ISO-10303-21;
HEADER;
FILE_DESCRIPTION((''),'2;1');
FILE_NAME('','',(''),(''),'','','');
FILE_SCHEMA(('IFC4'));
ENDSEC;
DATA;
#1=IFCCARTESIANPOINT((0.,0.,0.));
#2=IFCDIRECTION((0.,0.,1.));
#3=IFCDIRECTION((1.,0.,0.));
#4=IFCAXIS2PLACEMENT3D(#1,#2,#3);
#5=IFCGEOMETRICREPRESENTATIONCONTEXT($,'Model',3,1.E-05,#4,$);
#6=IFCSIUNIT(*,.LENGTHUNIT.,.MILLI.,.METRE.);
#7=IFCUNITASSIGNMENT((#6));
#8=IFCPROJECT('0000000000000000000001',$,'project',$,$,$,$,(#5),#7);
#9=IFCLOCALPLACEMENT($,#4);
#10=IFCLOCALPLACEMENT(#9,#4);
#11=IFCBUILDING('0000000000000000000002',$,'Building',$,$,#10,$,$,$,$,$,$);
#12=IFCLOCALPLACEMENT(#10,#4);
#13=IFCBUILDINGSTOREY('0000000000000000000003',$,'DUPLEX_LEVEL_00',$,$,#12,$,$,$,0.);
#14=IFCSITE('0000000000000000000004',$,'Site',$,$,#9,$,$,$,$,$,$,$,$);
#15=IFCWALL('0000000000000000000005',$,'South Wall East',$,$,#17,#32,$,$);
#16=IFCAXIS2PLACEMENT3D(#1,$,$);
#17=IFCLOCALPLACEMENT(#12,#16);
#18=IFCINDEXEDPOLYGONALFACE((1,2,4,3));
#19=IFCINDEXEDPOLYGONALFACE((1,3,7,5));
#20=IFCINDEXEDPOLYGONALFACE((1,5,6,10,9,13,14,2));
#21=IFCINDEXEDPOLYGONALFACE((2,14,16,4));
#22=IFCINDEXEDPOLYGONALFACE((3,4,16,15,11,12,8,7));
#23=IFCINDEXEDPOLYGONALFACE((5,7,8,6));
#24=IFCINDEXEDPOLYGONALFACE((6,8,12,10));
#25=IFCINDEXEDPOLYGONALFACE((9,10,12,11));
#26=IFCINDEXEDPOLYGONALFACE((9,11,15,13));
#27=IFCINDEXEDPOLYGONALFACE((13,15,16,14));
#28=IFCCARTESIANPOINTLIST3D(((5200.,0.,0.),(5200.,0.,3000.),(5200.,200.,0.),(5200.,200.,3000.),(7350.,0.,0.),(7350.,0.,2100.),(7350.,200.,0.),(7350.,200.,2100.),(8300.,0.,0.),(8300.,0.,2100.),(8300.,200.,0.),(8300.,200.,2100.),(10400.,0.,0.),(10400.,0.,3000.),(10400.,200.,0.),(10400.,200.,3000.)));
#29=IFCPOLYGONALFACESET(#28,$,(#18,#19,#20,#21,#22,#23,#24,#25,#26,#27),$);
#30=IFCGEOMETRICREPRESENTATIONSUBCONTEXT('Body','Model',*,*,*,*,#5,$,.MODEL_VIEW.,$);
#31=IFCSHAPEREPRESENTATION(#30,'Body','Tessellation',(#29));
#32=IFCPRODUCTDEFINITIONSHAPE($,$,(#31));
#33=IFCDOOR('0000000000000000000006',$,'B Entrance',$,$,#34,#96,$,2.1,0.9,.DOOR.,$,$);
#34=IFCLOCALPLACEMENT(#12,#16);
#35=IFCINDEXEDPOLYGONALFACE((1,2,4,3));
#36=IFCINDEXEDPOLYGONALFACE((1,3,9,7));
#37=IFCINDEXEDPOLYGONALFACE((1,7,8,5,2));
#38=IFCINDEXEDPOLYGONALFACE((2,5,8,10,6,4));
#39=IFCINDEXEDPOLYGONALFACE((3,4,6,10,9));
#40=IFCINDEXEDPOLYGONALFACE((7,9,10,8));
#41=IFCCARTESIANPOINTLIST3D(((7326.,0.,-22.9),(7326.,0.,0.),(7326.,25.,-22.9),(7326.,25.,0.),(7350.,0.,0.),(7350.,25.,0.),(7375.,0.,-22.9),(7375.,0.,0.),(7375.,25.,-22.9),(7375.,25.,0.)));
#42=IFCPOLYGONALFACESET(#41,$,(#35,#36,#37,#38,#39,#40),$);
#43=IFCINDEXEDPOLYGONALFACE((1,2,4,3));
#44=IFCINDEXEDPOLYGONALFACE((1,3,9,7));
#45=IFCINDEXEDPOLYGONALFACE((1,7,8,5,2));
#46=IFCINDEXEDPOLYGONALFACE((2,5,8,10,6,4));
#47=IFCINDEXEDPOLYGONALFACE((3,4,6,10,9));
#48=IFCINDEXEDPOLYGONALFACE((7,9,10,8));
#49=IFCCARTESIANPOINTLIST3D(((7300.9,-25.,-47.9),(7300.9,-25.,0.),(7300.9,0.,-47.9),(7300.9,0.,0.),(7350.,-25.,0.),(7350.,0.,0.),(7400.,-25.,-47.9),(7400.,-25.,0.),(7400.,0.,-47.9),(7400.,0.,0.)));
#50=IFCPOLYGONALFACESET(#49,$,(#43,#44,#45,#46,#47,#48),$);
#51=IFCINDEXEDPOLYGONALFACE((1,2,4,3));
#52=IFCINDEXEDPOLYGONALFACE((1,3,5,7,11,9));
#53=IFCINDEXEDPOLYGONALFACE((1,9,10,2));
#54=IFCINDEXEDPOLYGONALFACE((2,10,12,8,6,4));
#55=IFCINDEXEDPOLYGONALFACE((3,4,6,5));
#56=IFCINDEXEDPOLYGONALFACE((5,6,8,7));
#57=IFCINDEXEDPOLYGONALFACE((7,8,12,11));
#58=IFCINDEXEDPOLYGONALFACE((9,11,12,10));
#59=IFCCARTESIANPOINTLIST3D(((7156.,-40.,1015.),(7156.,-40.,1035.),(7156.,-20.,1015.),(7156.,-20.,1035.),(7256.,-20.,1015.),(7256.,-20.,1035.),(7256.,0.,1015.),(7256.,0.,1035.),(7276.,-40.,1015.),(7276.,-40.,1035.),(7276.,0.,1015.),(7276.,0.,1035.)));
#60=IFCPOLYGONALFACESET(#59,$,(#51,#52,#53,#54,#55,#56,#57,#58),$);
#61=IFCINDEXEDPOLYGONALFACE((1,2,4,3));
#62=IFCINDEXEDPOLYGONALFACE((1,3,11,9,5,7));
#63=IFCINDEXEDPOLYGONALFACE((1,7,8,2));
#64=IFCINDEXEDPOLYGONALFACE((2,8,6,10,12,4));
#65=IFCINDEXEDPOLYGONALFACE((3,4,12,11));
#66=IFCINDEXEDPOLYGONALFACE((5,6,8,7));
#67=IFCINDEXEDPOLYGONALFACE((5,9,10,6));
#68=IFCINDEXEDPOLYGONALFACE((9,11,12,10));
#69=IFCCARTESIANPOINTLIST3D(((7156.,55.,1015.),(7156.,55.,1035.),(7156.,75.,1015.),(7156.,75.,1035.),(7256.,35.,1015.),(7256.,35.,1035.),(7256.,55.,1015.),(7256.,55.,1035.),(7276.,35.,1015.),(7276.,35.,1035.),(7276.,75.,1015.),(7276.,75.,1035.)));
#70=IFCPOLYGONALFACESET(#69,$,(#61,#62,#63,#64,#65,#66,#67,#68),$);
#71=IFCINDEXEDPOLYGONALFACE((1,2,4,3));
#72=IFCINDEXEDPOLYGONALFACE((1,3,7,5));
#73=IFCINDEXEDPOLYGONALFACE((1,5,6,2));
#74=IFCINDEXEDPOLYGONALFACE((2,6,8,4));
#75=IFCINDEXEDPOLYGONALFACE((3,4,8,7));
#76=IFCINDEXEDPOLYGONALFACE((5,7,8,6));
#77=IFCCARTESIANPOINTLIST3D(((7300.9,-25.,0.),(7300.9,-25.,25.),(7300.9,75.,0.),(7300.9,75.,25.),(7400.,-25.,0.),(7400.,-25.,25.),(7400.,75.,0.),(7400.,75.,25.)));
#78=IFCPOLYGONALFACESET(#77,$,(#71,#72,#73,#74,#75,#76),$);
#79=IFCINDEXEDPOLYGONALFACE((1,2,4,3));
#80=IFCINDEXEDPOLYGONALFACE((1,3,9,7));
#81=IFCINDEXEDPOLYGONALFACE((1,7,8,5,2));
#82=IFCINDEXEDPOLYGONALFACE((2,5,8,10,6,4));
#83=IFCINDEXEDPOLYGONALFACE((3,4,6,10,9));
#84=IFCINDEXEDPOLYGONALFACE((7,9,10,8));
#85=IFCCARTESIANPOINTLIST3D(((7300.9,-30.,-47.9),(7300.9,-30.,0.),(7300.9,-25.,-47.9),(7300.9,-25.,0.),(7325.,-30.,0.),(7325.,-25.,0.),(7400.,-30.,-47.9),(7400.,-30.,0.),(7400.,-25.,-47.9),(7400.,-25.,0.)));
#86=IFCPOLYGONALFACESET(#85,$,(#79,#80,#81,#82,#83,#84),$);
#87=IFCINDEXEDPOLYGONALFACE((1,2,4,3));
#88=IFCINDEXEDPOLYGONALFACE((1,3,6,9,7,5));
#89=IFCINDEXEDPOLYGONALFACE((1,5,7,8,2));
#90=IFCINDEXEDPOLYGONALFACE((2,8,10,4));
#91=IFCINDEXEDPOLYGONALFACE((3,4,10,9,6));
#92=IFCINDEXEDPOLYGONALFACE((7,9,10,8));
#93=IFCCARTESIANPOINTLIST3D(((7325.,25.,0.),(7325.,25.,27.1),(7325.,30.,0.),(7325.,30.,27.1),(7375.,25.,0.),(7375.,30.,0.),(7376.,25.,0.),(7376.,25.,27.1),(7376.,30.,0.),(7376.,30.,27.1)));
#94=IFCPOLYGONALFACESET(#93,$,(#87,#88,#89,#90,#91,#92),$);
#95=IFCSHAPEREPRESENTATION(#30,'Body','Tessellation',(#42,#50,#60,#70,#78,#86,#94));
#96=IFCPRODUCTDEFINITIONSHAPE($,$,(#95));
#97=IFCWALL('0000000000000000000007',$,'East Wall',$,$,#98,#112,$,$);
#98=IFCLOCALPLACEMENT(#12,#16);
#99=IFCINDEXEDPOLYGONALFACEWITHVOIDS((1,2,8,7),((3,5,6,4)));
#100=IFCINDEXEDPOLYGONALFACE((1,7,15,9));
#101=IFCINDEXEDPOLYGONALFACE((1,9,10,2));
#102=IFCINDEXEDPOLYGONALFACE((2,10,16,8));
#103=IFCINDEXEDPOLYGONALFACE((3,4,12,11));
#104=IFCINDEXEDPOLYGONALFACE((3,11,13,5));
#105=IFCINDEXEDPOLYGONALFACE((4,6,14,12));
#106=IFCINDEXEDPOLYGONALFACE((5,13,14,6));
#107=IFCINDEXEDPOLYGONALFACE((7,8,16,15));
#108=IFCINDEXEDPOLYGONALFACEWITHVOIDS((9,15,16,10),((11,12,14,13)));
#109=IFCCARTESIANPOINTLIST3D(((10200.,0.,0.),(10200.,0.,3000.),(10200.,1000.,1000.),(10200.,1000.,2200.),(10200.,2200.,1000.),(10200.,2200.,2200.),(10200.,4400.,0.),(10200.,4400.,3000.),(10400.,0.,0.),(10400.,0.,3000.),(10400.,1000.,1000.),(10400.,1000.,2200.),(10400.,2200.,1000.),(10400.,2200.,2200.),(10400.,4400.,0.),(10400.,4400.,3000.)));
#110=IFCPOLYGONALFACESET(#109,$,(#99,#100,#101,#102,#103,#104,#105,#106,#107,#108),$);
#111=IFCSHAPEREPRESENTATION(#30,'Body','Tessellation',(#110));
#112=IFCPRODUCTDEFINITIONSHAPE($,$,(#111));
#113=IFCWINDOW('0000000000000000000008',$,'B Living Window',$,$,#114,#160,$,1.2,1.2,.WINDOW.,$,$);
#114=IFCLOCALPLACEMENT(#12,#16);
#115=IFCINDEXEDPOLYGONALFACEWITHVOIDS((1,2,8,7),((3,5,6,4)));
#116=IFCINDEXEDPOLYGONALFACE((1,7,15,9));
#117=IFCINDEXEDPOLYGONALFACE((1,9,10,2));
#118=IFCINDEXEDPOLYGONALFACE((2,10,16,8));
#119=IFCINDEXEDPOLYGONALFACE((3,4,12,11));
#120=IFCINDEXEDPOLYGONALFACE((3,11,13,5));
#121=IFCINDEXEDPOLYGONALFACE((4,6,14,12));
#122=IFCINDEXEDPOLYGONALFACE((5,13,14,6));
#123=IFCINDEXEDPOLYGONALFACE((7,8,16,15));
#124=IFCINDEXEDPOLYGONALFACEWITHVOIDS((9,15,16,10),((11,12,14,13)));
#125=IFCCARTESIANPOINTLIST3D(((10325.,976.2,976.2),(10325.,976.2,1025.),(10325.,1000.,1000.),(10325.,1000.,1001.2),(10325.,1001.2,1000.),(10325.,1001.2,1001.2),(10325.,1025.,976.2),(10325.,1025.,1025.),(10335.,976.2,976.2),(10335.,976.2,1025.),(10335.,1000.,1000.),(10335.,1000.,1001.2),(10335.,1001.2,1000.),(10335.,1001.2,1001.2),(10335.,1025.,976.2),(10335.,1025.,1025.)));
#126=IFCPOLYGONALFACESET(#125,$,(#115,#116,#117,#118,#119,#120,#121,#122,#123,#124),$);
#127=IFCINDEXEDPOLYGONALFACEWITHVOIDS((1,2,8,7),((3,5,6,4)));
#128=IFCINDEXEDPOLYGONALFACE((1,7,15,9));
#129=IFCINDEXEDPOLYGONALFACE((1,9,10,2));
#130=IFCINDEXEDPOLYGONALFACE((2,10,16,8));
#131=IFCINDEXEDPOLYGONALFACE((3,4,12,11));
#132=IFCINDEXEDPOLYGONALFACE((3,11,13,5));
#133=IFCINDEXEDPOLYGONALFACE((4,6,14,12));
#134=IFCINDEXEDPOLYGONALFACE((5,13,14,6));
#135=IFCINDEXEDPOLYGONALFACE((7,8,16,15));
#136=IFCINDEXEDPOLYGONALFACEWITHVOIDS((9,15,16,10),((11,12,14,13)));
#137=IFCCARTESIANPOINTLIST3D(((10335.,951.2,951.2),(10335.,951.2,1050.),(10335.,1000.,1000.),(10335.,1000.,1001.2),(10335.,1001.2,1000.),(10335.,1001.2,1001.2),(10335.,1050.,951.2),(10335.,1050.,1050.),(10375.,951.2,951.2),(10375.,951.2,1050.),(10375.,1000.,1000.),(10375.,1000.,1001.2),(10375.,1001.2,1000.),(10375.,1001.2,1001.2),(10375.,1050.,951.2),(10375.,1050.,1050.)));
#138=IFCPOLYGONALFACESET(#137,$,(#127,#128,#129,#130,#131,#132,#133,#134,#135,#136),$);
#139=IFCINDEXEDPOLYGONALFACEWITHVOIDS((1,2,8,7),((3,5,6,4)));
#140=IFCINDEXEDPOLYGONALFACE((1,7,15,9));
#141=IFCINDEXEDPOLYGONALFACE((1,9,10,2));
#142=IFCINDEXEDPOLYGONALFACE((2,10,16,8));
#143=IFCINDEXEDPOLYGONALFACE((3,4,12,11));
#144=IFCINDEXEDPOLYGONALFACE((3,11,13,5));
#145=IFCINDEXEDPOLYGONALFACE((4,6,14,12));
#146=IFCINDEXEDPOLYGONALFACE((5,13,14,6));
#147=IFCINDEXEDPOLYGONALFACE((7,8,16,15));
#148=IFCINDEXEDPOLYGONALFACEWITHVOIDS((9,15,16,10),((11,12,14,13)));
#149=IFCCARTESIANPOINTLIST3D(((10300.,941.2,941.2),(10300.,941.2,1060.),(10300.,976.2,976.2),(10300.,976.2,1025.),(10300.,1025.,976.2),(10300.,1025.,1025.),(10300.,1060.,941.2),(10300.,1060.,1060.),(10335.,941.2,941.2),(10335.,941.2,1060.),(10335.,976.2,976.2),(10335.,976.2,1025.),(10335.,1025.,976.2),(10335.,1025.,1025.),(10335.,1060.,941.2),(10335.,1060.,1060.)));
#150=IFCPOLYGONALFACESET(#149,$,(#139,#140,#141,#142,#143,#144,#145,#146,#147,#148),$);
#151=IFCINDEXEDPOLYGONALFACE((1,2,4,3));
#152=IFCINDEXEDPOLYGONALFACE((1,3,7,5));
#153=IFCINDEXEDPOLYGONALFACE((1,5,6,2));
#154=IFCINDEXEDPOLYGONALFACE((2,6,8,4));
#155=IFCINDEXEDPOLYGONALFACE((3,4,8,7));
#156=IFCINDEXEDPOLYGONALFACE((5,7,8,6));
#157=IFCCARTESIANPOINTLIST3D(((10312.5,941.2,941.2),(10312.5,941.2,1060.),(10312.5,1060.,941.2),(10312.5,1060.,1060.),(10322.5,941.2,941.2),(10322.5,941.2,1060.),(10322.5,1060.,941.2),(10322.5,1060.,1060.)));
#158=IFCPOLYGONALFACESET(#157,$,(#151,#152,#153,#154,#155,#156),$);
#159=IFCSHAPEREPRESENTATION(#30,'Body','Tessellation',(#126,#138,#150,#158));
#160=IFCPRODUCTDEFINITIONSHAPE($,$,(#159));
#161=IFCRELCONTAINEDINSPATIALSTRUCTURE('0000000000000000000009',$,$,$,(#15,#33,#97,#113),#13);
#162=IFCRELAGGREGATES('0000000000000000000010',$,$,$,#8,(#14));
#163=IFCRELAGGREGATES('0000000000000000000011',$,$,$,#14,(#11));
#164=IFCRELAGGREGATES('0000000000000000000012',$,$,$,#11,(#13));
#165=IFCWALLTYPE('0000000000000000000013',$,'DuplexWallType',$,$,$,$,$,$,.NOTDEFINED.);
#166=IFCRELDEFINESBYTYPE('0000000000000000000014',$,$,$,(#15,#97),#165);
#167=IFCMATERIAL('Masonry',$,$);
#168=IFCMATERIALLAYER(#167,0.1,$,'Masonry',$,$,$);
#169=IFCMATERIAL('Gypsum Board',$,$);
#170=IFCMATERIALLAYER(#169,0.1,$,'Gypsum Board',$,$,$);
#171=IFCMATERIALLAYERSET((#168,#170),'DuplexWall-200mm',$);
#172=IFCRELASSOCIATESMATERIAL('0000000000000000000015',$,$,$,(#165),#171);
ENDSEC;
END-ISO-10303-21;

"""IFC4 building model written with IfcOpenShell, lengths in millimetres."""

from ifc_helpers import new_model, si_unit, frame, origin_with_axes, place, context, subcontext, project, spatial, line, indexed_curve, outline, extrude, material, layer, layer_set, type_object, element, fill, save


model = new_model("IFC4")

# Units and contexts
model_context = context("Model", 3, precision=1e-05, world=origin_with_axes())
body_context = subcontext(model_context, "Body", "Model", "MODEL_VIEW")
ifc_project = project(units=[si_unit("LENGTHUNIT", "METRE", prefix="MILLI")], contexts=[model_context])

# Site, building, storey
site_placement = place(None, origin_with_axes())
site = spatial("IfcSite", under=ifc_project, at=site_placement, Name="Site")
building_placement = place(site_placement, origin_with_axes())
building = spatial("IfcBuilding", under=site, at=building_placement, Name="Building")
storey_placement = place(building_placement, origin_with_axes())
storey = spatial("IfcBuildingStorey", under=building, at=storey_placement, Name="DUPLEX_LEVEL_00", Elevation=0.0)

# Wall, opening, door
ifc_material_1 = material(Name="Masonry")
ifc_layer_1 = layer(ifc_material_1, 0.1, Name="Masonry")
ifc_material_2 = material(Name="Gypsum Board")
ifc_layer_2 = layer(ifc_material_2, 0.1, Name="Gypsum Board")
ifc_layer_set = layer_set([ifc_layer_1, ifc_layer_2], Name="DuplexWall-200mm")
wall_type = type_object("IfcWallType", Name="DuplexWallType", PredefinedType="NOTDEFINED", material=ifc_layer_set)
wall_1_placement = place(storey_placement, frame((5200.0, 0.0, 0.0), z_axis=(0.0, 0.0, 1.0), x_axis=(1.0, 0.0, 0.0)))
wall_1 = element("IfcWall", 1, at=wall_1_placement, inside=storey, type_object=wall_type, Name="South Wall East", context=body_context, shape_type="SweptSolid", body=[
    extrude(outline(indexed_curve([(0.0, 0.0), (0.0, 200.0), (5200.0, 200.0), (5200.0, 0.0), (0.0, 0.0)], self_intersect=False)), origin_with_axes(), (0.0, 0.0, 1.0), 3000.0),
])
opening_1_placement = place(wall_1_placement, frame((2150.0, -25.0, 0.0), z_axis=(0.0, 0.0, 1.0), x_axis=(1.0, 0.0, 0.0)))
opening_1 = element("IfcOpeningElement", 2, at=opening_1_placement, cuts=wall_1, context=body_context, shape_type="SweptSolid", body=[
    extrude(outline(indexed_curve([(0.0, 0.0), (0.0, 250.0), (950.0, 250.0), (950.0, 0.0), (0.0, 0.0)], self_intersect=False)), origin_with_axes(), (0.0, 0.0, 1.0), 2100.0),
])
door_1_placement = place(storey_placement, frame((7350.0, -25.0, 0.0), z_axis=(0.0, 0.0, 1.0), x_axis=(1.0, 0.0, 0.0)))
door_1 = element("IfcDoor", 3, at=door_1_placement, inside=storey, Name="B Entrance", OverallHeight=2.1, OverallWidth=0.9, PredefinedType="DOOR", context=body_context, shape_type="SweptSolid", body=[
    extrude(outline(indexed_curve([(0.0, 0.0), (0.0, 2.1), (0.9, 2.1), (0.9, 0.0), (-24.1, 0.0), (-24.1, -22.9), (25.0, -22.9), (25.0, 0.0)], segments=[line(1, 2, 3, 4, 5, 6, 7, 8, 1)])), frame((0.0, 25.0, 0.0), z_axis=(0.0, -1.0, 0.0), x_axis=(1.0, 0.0, 0.0)), (0.0, 0.0, -1.0), 25.0),
    extrude(outline(indexed_curve([(0.0, 0.0), (0.0, 2.1), (0.9, 2.1), (0.9, 0.0), (-49.0, 0.0), (-49.0, -47.9), (50.0, -47.9), (50.0, 0.0)], segments=[line(1, 2, 3, 4, 5, 6, 7, 8, 1)])), frame((0.0, 0.0, 0.0), z_axis=(0.0, -1.0, 0.0), x_axis=(1.0, 0.0, 0.0)), (0.0, 0.0, -1.0), 25.0),
    extrude(outline(indexed_curve([(0.0, 0.0), (-49.0, 0.0), (-49.0, 35.0), (0.0, 35.0)], segments=[line(1, 2, 3, 4, 1)])), frame((25.0, 25.0, 25.0), z_axis=(0.0, 0.0, 1.0), x_axis=(1.0, 0.0, 0.0)), (0.0, 0.0, 1.0), -47.9),
    extrude(outline(indexed_curve([(0.0, 0.0), (0.0, -40.0), (-120.0, -40.0), (-120.0, -20.0), (-20.0, -20.0), (-20.0, 0.0)], segments=[line(1, 2, 3, 4, 5, 6, 1)])), frame((-74.1, 25.0, 1015.0), z_axis=(0.0, 0.0, 1.0), x_axis=(1.0, 0.0, 0.0)), (0.0, 0.0, 1.0), 20.0),
    extrude(outline(indexed_curve([(0.0, 0.0), (0.0, 40.0), (-120.0, 40.0), (-120.0, 20.0), (-20.0, 20.0), (-20.0, 0.0)], segments=[line(1, 2, 3, 4, 5, 6, 1)])), frame((-74.1, 60.0, 1015.0), z_axis=(0.0, 0.0, 1.0), x_axis=(1.0, 0.0, 0.0)), (0.0, 0.0, 1.0), 20.0),
    extrude(outline(indexed_curve([(0.0, 0.0), (-99.0, 0.0), (-99.0, 100.0), (0.0, 100.0)], segments=[line(1, 2, 3, 4, 1)])), frame((50.0, 0.0, 0.0), z_axis=(0.0, 0.0, 1.0), x_axis=(1.0, 0.0, 0.0)), (0.0, 0.0, 1.0), 25.0),
    extrude(outline(indexed_curve([(0.0, 0.0), (0.0, 27.1), (51.0, 27.1), (51.0, 0.0), (-24.0, 0.0), (-24.0, -47.9), (75.0, -47.9), (75.0, 0.0)], segments=[line(1, 2, 3, 4, 5, 6, 7, 8, 1)])), frame((-25.0, -5.0, 0.0), z_axis=(0.0, -1.0, 0.0), x_axis=(1.0, 0.0, 0.0)), (0.0, 0.0, -1.0), 5.0),
    extrude(outline(indexed_curve([(0.0, 0.0), (0.0, 27.1), (51.0, 27.1), (51.0, 0.0), (1.0, 0.0), (1.0, -22.9), (50.0, -22.9), (50.0, 0.0)], segments=[line(1, 2, 3, 4, 5, 6, 7, 8, 1)])), frame((-25.0, 50.0, 0.0), z_axis=(0.0, -1.0, 0.0), x_axis=(1.0, 0.0, 0.0)), (0.0, 0.0, -1.0), 5.0),
])
fill(opening_1, door_1)

# Wall, opening, window
wall_2_placement = place(storey_placement, frame((10400.0, 0.0, 0.0), z_axis=(0.0, 0.0, 1.0), x_axis=(0.0, 1.0, 0.0)))
wall_2 = element("IfcWall", 4, at=wall_2_placement, inside=storey, type_object=wall_type, Name="East Wall", context=body_context, shape_type="SweptSolid", body=[
    extrude(outline(indexed_curve([(0.0, 0.0), (0.0, 200.0), (4400.0, 200.0), (4400.0, 0.0), (0.0, 0.0)], self_intersect=False)), origin_with_axes(), (0.0, 0.0, 1.0), 3000.0),
])
opening_2_placement = place(wall_2_placement, frame((1000.0, -25.0, 1000.0), z_axis=(0.0, 0.0, 1.0), x_axis=(1.0, 0.0, 0.0)))
opening_2 = element("IfcOpeningElement", 5, at=opening_2_placement, cuts=wall_2, context=body_context, shape_type="SweptSolid", body=[
    extrude(outline(indexed_curve([(0.0, 0.0), (0.0, 250.0), (1200.0, 250.0), (1200.0, 0.0), (0.0, 0.0)], self_intersect=False)), origin_with_axes(), (0.0, 0.0, 1.0), 1200.0),
])
window_1_placement = place(storey_placement, frame((10425.0, 1000.0, 1000.0), z_axis=(0.0, 0.0, 1.0), x_axis=(0.0, 1.0, 0.0)))
window_1 = element("IfcWindow", 6, at=window_1_placement, inside=storey, Name="B Living Window", OverallHeight=1.2, OverallWidth=1.2, PredefinedType="WINDOW", context=body_context, shape_type="SweptSolid", body=[
    extrude(outline(indexed_curve([(0.0, 0.0), (1.2, 0.0), (1.2, 1.2), (0.0, 1.2)], segments=[line(1, 2, 3, 4, 1)]), holes=[indexed_curve([(25.0, 25.0), (-23.8, 25.0), (-23.8, -23.8), (25.0, -23.8)], segments=[line(1, 2, 3, 4, 1)])]), frame((0.0, 90.0, 0.0), z_axis=(0.0, -1.0, 0.0), x_axis=(1.0, 0.0, 0.0)), (0.0, 0.0, -1.0), 10.0),
    extrude(outline(indexed_curve([(0.0, 0.0), (1.2, 0.0), (1.2, 1.2), (0.0, 1.2)], segments=[line(1, 2, 3, 4, 1)]), holes=[indexed_curve([(50.0, 50.0), (-48.8, 50.0), (-48.8, -48.8), (50.0, -48.8)], segments=[line(1, 2, 3, 4, 1)])]), frame((0.0, 50.0, 0.0), z_axis=(0.0, -1.0, 0.0), x_axis=(1.0, 0.0, 0.0)), (0.0, 0.0, -1.0), 40.0),
    extrude(outline(indexed_curve([(0.0, 0.0), (-48.8, 0.0), (-48.8, -48.8), (0.0, -48.8)], segments=[line(1, 2, 3, 4, 1)]), holes=[indexed_curve([(35.0, 35.0), (-83.8, 35.0), (-83.8, -83.8), (35.0, -83.8)], segments=[line(1, 2, 3, 4, 1)])]), frame((25.0, 90.0, 25.0), z_axis=(0.0, -1.0, 0.0), x_axis=(1.0, 0.0, 0.0)), (0.0, 0.0, -1.0), 35.0),
    extrude(outline(indexed_curve([(35.0, 35.0), (-83.8, 35.0), (-83.8, -83.8), (35.0, -83.8)], segments=[line(1, 2, 3, 4, 1)])), frame((25.0, 102.5, 25.0), z_axis=(0.0, -1.0, 0.0), x_axis=(1.0, 0.0, 0.0)), (0.0, 0.0, -1.0), 10.0),
])
fill(opening_2, window_1)

save(model, "model.ifc")
